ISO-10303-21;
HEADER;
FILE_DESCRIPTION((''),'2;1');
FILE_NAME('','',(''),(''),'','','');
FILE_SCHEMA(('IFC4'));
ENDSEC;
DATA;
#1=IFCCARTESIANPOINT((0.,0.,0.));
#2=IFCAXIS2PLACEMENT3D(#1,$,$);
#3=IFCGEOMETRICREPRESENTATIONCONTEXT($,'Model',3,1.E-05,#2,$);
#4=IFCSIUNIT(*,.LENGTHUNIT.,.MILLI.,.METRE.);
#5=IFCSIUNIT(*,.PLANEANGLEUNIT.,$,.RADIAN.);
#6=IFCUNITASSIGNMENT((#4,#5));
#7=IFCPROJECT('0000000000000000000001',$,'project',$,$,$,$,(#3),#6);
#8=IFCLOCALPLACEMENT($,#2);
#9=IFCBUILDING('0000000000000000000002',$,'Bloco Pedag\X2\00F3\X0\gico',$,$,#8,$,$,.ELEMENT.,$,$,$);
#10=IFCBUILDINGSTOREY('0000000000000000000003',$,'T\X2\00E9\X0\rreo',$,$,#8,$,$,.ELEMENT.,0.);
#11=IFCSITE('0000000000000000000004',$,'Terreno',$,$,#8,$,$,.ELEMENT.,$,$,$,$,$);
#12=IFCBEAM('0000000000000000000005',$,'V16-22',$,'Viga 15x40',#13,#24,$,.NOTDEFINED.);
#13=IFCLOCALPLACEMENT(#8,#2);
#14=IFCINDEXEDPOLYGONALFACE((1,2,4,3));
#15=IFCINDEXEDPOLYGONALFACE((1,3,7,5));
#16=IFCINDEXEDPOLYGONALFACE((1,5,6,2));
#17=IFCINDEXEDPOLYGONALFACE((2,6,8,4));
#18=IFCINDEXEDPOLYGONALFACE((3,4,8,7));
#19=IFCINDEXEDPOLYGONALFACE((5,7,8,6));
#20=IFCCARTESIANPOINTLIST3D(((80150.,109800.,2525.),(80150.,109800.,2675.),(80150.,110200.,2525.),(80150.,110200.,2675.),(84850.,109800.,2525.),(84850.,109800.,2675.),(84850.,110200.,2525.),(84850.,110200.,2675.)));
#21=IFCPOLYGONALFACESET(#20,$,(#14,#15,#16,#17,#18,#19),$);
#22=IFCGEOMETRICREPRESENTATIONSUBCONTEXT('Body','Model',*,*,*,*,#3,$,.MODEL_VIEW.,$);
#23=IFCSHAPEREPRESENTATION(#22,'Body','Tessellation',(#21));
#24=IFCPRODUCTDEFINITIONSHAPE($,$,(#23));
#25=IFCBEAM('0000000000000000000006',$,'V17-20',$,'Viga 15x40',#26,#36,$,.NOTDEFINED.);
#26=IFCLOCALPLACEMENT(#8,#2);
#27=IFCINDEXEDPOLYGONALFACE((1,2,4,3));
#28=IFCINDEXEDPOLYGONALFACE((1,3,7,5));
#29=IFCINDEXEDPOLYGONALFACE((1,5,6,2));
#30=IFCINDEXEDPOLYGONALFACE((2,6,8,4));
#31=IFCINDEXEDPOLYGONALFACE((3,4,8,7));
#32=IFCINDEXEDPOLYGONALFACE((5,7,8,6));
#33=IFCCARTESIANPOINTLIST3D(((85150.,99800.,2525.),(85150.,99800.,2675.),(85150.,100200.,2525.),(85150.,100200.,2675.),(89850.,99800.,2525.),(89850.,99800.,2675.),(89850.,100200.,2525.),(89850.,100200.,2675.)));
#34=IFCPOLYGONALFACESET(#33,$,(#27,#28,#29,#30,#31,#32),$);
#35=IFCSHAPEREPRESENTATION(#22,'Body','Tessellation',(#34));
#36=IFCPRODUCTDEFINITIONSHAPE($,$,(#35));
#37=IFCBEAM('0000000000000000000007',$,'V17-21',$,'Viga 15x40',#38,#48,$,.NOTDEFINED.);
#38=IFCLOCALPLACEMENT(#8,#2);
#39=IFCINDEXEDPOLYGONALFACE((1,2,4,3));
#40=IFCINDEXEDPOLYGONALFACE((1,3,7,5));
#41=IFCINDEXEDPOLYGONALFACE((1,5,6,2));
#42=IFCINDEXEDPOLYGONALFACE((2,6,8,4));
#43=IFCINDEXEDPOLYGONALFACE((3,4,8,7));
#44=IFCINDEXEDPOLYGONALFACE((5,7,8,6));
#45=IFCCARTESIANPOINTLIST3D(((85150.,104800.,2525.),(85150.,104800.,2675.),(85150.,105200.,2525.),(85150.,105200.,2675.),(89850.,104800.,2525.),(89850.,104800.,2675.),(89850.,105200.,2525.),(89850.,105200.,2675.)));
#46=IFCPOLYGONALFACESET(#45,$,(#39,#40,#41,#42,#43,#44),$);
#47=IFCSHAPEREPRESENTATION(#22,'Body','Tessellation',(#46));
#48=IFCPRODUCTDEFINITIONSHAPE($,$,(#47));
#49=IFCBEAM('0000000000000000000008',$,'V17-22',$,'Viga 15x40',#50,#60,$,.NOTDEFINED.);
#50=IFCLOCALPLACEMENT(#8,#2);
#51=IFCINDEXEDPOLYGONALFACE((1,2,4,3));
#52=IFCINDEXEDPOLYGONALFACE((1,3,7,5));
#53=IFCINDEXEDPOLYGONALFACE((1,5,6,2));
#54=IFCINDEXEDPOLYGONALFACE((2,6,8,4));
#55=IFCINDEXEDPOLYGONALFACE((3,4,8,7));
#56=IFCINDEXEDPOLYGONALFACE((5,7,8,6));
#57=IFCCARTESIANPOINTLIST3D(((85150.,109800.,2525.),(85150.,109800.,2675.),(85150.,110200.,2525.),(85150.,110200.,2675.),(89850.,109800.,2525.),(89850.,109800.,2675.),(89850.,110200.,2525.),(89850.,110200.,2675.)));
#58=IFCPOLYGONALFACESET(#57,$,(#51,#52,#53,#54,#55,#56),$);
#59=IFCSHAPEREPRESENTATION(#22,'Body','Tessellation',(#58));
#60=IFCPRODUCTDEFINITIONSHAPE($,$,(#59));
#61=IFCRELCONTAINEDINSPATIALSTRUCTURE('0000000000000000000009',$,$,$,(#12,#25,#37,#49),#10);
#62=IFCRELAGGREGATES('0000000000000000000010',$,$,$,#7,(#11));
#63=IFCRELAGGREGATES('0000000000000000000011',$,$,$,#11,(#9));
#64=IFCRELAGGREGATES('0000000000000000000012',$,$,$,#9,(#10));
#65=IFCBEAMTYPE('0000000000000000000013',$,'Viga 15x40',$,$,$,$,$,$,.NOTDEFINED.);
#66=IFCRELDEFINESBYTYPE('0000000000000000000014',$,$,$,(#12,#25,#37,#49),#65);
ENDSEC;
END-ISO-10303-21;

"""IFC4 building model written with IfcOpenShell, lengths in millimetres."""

from ifc_helpers import new_model, si_unit, frame, origin, origin_2d, place, context, subcontext, project, spatial, rectangle, extrude, type_object, element, save


model = new_model("IFC4")

# Units and contexts
model_context = context("Model", 3, precision=1e-05, world=origin())
body_context = subcontext(model_context, "Body", "Model", "MODEL_VIEW")
ifc_project = project(units=[si_unit("LENGTHUNIT", "METRE", prefix="MILLI"), si_unit("PLANEANGLEUNIT", "RADIAN")], contexts=[model_context])

# Site, building, storey
placement = place(None, origin())
site = spatial("IfcSite", under=ifc_project, at=placement, Name="Terreno", CompositionType="ELEMENT")
building = spatial("IfcBuilding", under=site, at=placement, Name="Bloco Pedagógico", CompositionType="ELEMENT")
storey = spatial("IfcBuildingStorey", under=building, at=placement, Name="Térreo", CompositionType="ELEMENT", Elevation=0.0)

# Beams
beam_type = type_object("IfcBeamType", Name="Viga 15x40", PredefinedType="NOTDEFINED")
for number, where, z_axis, x_axis, name in (
    (1, (80150.0, 110000.0, 2600.0), (1.0, 0.0, 0.0), (0.0, 1.0, 0.0), "V16-22"),
    (2, (85150.0, 100000.0, 2600.0), (1.0, 0.0, 0.0), (0.0, 1.0, 0.0), "V17-20"),
    (3, (85150.0, 105000.0, 2600.0), (1.0, 0.0, 0.0), (0.0, 1.0, 0.0), "V17-21"),
    (4, (85150.0, 110000.0, 2600.0), (1.0, 0.0, 0.0), (0.0, 1.0, 0.0), "V17-22"),
):
    element("IfcBeam", number, at=place(None, frame(where, z_axis=z_axis, x_axis=x_axis)), inside=storey, type_object=beam_type, Name=name, ObjectType="Viga 15x40", PredefinedType="NOTDEFINED", context=body_context, shape_type="SweptSolid", body=[
        extrude(rectangle(XDim=400.0, YDim=150.0, at=origin_2d()), None, (0.0, 0.0, 1.0), 4700.0),
    ])

save(model, "model.ifc")
